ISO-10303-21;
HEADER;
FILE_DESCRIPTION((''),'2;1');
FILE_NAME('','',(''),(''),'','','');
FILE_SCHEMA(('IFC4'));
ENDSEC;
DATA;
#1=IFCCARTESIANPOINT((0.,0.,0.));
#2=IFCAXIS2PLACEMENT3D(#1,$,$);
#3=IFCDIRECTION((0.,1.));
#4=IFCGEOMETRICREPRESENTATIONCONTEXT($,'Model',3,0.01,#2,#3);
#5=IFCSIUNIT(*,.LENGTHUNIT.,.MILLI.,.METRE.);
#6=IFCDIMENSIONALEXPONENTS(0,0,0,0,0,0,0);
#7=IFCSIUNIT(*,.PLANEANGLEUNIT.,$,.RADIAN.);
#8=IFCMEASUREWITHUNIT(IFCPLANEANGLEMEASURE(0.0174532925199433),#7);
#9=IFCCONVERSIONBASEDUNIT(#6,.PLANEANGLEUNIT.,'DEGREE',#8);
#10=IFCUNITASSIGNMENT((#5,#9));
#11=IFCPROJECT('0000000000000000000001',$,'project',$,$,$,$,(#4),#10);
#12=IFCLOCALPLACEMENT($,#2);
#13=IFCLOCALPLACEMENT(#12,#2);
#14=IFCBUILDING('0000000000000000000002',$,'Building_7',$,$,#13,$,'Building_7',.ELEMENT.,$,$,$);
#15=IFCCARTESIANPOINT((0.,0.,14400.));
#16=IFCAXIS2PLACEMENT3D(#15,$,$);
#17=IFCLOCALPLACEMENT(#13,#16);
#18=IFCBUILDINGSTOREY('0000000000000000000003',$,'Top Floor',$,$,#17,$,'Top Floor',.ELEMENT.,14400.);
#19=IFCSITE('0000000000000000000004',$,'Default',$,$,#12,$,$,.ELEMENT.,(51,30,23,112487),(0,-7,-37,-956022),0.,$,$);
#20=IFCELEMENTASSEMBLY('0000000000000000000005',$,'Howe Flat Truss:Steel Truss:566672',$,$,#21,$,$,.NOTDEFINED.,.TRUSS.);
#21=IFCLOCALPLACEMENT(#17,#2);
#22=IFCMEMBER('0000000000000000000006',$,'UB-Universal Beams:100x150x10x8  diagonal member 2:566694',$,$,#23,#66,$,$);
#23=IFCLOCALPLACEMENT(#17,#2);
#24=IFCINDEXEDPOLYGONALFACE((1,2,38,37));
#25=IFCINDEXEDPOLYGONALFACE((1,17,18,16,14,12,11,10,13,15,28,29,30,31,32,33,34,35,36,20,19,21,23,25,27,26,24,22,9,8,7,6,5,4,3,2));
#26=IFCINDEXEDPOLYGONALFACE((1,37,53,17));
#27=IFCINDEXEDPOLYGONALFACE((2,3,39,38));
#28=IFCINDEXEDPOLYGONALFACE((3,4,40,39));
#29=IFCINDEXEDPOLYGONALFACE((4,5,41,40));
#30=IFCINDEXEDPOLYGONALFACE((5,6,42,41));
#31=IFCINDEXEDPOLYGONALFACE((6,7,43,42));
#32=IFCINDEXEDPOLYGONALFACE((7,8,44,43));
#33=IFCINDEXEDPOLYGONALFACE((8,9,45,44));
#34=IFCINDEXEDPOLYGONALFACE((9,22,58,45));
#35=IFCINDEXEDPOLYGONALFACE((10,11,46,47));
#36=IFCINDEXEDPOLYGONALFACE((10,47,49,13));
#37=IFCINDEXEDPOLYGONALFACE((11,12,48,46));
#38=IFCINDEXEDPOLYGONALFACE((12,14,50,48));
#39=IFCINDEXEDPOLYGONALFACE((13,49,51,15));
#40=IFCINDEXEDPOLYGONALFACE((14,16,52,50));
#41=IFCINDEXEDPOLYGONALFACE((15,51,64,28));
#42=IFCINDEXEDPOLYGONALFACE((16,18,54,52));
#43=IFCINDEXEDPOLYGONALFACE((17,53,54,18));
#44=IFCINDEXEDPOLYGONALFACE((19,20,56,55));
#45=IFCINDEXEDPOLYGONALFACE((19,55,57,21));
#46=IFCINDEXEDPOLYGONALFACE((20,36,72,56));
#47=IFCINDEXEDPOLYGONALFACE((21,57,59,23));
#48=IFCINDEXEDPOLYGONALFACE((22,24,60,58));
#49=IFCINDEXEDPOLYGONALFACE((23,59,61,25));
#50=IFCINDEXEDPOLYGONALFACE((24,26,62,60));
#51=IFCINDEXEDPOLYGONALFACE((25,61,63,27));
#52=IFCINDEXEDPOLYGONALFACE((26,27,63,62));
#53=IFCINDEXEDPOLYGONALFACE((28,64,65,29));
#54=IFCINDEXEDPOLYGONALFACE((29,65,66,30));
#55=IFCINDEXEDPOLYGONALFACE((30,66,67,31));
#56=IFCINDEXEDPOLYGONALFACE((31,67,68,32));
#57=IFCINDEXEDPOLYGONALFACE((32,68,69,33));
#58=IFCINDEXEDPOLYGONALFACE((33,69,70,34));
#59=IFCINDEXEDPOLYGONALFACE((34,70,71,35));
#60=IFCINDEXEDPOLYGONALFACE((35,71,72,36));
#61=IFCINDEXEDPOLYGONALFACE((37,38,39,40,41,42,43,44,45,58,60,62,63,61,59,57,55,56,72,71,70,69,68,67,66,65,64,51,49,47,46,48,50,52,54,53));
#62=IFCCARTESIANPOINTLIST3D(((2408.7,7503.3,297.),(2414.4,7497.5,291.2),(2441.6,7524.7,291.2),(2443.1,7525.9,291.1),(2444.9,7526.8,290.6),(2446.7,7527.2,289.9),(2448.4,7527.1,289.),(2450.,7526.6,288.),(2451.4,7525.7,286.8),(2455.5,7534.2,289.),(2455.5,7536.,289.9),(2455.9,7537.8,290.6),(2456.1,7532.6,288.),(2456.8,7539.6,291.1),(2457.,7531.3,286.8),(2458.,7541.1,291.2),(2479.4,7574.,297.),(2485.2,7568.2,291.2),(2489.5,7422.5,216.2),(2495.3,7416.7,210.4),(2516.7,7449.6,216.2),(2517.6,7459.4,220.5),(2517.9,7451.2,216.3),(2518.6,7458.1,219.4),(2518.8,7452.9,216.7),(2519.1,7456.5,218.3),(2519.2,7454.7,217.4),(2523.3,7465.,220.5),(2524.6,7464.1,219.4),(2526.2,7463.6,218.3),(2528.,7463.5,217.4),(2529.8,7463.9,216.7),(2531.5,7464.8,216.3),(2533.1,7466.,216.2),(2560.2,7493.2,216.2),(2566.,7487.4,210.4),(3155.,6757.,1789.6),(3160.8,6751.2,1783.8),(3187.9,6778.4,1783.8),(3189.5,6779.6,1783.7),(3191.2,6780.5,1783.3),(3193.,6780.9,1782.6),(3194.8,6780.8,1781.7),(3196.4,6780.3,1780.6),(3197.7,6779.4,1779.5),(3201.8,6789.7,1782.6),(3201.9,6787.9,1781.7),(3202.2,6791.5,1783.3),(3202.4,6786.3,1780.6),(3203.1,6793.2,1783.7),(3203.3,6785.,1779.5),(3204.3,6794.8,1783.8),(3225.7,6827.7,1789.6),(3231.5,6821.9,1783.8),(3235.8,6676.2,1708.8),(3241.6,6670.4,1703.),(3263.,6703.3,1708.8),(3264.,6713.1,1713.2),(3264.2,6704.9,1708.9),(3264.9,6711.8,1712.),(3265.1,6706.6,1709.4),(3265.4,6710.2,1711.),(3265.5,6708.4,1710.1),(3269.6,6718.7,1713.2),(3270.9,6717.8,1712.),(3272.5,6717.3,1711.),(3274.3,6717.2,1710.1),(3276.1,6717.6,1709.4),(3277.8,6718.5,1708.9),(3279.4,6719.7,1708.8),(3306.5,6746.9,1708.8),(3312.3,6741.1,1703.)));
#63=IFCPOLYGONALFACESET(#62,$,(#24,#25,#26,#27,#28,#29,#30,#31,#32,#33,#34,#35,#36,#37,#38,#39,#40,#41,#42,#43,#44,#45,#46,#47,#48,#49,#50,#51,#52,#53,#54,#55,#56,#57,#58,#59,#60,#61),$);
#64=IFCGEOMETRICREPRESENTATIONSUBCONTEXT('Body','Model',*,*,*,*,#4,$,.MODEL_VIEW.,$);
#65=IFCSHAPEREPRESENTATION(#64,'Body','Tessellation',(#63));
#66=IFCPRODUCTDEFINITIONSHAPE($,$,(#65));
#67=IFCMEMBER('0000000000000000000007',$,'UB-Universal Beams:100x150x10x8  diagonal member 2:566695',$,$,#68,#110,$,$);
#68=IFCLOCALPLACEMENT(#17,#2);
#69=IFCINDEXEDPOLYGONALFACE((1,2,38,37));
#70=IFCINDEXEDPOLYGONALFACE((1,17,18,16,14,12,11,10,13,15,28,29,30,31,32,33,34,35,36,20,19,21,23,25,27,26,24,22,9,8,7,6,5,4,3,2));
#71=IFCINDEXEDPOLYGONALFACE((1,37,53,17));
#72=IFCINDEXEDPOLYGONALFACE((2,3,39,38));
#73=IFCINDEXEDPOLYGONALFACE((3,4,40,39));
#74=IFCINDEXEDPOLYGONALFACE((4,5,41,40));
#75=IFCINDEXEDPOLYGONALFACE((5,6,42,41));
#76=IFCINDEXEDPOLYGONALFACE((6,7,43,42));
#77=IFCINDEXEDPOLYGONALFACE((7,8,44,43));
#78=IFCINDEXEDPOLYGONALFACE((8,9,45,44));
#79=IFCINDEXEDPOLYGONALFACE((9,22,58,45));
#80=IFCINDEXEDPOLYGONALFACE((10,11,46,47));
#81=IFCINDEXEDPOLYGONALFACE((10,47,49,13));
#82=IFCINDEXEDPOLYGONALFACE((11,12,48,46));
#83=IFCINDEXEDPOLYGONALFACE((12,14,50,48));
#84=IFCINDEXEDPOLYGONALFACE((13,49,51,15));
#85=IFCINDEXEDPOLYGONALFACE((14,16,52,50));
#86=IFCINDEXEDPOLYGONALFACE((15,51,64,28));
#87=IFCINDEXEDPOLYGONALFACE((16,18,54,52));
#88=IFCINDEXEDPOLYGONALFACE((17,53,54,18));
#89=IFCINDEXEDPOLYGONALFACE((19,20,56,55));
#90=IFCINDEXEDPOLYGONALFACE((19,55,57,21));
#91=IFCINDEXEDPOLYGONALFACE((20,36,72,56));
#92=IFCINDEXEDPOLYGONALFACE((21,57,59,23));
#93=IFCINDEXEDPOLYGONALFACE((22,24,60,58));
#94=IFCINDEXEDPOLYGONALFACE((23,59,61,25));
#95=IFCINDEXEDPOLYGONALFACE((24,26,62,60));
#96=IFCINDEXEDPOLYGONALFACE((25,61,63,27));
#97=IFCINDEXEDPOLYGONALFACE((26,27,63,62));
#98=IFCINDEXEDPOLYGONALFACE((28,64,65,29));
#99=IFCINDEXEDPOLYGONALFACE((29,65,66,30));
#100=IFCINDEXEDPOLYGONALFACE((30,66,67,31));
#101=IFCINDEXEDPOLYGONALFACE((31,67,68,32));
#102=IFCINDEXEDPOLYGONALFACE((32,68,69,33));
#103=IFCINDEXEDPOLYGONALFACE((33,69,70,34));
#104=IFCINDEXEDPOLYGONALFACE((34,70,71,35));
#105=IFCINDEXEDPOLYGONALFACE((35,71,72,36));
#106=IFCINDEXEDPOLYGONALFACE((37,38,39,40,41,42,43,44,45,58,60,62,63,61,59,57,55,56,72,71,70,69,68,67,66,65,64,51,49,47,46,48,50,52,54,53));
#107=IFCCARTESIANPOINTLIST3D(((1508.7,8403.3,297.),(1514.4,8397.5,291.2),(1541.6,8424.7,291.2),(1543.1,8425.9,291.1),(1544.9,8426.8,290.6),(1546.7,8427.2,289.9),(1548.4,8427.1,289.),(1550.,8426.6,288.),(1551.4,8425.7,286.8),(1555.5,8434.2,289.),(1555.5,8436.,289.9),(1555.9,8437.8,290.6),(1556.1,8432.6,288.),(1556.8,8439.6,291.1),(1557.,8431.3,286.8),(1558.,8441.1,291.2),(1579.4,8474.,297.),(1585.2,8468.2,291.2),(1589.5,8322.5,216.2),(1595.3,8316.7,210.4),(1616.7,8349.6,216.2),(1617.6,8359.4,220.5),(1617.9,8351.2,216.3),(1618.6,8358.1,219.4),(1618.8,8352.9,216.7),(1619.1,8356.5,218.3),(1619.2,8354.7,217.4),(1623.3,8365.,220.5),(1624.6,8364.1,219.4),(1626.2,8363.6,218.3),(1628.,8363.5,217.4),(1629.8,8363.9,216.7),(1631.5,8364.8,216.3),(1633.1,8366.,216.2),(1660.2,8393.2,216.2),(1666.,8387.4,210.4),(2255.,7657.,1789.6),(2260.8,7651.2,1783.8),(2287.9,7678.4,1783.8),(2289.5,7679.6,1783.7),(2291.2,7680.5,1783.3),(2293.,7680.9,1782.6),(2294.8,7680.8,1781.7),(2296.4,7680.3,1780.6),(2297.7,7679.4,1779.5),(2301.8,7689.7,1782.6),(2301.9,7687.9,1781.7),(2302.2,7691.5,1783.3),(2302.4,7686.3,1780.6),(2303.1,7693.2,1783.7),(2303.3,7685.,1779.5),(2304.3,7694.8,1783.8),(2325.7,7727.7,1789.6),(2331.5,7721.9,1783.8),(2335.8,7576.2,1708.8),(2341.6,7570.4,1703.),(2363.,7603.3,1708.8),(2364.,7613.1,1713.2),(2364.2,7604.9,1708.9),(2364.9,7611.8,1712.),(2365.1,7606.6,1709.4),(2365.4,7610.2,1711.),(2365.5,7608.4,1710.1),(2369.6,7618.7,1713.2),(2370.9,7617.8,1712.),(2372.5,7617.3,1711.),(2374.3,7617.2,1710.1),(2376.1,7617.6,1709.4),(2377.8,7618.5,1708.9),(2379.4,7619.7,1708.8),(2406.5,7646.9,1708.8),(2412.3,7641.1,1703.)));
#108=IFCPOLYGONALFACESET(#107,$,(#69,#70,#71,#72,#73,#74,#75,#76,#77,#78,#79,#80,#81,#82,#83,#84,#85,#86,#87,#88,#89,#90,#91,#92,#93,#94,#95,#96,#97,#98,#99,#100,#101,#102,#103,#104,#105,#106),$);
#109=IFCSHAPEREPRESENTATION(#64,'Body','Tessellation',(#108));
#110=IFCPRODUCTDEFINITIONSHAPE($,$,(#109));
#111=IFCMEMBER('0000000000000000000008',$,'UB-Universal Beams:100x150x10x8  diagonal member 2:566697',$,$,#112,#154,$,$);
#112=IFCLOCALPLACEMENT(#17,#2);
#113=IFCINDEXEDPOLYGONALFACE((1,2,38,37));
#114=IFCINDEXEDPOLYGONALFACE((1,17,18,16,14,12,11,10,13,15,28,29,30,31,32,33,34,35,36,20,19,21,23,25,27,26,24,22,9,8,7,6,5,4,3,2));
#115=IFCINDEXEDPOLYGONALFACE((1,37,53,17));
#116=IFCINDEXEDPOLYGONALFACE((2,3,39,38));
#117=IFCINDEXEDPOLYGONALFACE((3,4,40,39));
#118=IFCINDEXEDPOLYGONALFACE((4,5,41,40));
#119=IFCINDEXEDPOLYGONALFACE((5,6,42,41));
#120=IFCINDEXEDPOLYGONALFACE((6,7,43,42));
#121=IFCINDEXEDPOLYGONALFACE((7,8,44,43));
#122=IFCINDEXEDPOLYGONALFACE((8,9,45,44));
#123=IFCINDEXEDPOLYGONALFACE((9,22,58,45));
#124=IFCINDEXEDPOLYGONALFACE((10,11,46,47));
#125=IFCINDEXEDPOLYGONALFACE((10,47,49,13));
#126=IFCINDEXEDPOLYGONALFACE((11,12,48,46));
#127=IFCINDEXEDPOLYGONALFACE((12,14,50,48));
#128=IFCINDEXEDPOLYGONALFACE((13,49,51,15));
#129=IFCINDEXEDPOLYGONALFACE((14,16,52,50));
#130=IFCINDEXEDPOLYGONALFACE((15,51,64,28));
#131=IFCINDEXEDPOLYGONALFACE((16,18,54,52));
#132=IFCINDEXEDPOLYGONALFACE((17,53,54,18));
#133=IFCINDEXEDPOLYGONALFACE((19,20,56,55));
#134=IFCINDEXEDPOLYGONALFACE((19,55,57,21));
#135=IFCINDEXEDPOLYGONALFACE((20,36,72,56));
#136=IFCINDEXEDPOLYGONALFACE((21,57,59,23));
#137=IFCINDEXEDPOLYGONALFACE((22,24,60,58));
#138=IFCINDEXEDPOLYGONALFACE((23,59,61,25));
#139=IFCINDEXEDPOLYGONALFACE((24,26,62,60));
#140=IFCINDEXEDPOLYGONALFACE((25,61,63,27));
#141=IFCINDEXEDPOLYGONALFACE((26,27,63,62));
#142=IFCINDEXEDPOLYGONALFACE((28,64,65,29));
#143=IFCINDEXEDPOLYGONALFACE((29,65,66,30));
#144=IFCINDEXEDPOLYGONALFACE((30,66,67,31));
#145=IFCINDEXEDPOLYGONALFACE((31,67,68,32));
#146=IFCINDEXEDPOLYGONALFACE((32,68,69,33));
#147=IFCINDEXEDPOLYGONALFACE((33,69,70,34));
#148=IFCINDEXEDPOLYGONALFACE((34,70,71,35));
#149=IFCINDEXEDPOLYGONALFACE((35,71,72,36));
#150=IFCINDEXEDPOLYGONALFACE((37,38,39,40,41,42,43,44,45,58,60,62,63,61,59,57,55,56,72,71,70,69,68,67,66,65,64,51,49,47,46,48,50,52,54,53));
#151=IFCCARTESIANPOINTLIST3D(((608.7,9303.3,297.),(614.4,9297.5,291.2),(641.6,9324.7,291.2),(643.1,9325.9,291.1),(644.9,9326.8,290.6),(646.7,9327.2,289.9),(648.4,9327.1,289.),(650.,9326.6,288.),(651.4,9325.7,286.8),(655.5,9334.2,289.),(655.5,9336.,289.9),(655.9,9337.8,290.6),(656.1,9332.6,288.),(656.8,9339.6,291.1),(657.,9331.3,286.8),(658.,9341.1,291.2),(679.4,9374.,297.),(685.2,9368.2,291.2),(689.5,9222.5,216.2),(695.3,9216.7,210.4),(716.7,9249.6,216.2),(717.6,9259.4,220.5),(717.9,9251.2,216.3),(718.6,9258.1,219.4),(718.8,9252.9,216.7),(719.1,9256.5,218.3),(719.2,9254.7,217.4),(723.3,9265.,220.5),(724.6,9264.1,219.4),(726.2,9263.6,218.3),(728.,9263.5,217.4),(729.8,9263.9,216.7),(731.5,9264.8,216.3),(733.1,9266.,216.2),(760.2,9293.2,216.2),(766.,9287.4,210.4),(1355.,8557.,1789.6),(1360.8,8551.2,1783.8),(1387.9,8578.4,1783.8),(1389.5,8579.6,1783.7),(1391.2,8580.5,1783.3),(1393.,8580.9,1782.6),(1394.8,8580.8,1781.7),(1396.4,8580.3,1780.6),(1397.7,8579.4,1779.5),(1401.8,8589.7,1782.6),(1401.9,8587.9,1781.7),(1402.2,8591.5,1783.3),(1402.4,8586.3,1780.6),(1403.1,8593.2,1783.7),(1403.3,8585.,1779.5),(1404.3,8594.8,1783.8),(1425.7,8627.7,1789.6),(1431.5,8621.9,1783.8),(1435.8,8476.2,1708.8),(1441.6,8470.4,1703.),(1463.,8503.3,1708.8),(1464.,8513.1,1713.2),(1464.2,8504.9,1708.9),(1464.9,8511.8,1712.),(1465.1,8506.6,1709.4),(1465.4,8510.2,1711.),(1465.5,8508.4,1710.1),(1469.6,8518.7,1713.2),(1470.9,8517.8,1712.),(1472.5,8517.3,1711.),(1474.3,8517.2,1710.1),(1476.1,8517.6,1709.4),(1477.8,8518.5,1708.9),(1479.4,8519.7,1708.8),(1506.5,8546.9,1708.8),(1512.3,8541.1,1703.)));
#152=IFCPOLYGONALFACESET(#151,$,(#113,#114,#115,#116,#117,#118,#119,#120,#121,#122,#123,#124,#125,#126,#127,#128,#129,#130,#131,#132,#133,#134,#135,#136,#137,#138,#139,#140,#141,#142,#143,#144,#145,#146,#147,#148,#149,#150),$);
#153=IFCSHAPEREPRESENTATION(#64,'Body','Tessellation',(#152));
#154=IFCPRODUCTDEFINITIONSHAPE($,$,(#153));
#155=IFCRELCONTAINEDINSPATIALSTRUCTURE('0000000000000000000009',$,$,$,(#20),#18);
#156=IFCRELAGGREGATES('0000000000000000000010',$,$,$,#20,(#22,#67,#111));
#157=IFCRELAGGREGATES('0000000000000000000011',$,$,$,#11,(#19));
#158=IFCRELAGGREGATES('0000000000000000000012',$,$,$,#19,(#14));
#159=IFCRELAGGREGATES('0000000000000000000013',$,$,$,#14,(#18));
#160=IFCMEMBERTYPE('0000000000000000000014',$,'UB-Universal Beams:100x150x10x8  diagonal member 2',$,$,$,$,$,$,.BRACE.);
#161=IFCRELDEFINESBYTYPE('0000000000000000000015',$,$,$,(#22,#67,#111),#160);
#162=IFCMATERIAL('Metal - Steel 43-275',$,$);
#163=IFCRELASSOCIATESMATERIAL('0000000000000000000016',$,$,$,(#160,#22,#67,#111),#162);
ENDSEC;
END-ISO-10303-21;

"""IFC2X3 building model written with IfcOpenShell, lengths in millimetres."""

from ifc_helpers import new_model, entity, si_unit, converted_unit, direction, frame, frame_2d, origin, place, context, subcontext, project, spatial, polyline, circle_curve, parameter, trimmed, segment, composite_curve, outline, extrude, source, transform, mapped, material, type_object, type_shapes, element, aggregate, save


model = new_model("IFC2X3")

# Units and contexts
model_context = context("Model", 3, precision=0.01, world=origin(), true_north=direction((0.0, 1.0)))
body_context = subcontext(model_context, "Body", "Model", "MODEL_VIEW")
ifc_project = project(units=[si_unit("LENGTHUNIT", "METRE", prefix="MILLI"), converted_unit("PLANEANGLEUNIT", "DEGREE", entity("IfcPlaneAngleMeasure", 0.0174532925199433), si_unit("PLANEANGLEUNIT", "RADIAN"), dimensions=[0, 0, 0, 0, 0, 0, 0])], contexts=[model_context])

# Site, building, storey
site_placement = place(None, origin())
site = spatial("IfcSite", under=ifc_project, at=site_placement, Name="Default", CompositionType="ELEMENT", RefLatitude=(51, 30, 23, 112487), RefLongitude=(0, -7, -37, -956022), RefElevation=0.0)
building_placement = place(site_placement, origin())
building = spatial("IfcBuilding", under=site, at=building_placement, Name="Building_7", LongName="Building_7", CompositionType="ELEMENT")
storey_placement = place(building_placement, frame((0.0, 0.0, 14400.0)))
storey = spatial("IfcBuildingStorey", under=building, at=storey_placement, Name="Top Floor", LongName="Top Floor", CompositionType="ELEMENT", Elevation=14400.0)

# Shared definitions
ifc_material = material(Name="Metal - Steel 43-275")

# Element assembly
assembly_1_placement = place(storey_placement, origin())
assembly_1 = element("IfcElementAssembly", 1, at=assembly_1_placement, inside=storey, Name="Howe Flat Truss:Steel Truss:566672", AssemblyPlace="NOTDEFINED", PredefinedType="TRUSS")

# Members
member_type_1 = type_object("IfcMemberType", Name="UB-Universal Beams:100x150x10x8  diagonal member 2", PredefinedType="BRACE", material=ifc_material)
shared_shape_1 = source(origin(), body_context, "Body", "SweptSolid", [
    extrude(outline(composite_curve([segment(polyline([(-50.0, -65.0), (-50.0, -75.0)]), True, "CONTINUOUS"), segment(polyline([(-50.0, -75.0), (50.0, -75.0)]), True, "CONTINUOUS"), segment(polyline([(50.0, -75.0), (50.0, -65.0)]), True, "CONTINUOUS"), segment(polyline([(50.0, -65.0), (11.6, -65.0)]), True, "CONTINUOUS"), segment(trimmed(circle_curve(frame_2d((11.6, -57.4), x_axis=(1.0, 0.0)), 7.6), [parameter(180.0)], [parameter(270.0)], True, "PARAMETER"), False, "CONTINUOUS"), segment(polyline([(4.0, -57.4), (4.0, 57.4)]), True, "CONTINUOUS"), segment(trimmed(circle_curve(frame_2d((11.6, 57.4), x_axis=(1.0, 0.0)), 7.6), [parameter(90.0)], [parameter(180.0)], True, "PARAMETER"), False, "CONTINUOUS"), segment(polyline([(11.6, 65.0), (50.0, 65.0)]), True, "CONTINUOUS"), segment(polyline([(50.0, 65.0), (50.0, 75.0)]), True, "CONTINUOUS"), segment(polyline([(50.0, 75.0), (-50.0, 75.0)]), True, "CONTINUOUS"), segment(polyline([(-50.0, 75.0), (-50.0, 65.0)]), True, "CONTINUOUS"), segment(polyline([(-50.0, 65.0), (-11.6, 65.0)]), True, "CONTINUOUS"), segment(trimmed(circle_curve(frame_2d((-11.6, 57.4), x_axis=(1.0, 0.0)), 7.6), [parameter(360.0)], [parameter(90.0)], True, "PARAMETER"), False, "CONTINUOUS"), segment(polyline([(-4.0, 57.4), (-4.0, -57.4)]), True, "CONTINUOUS"), segment(trimmed(circle_curve(frame_2d((-11.6, -57.4), x_axis=(1.0, 0.0)), 7.6), [parameter(270.0)], [parameter(360.0)], True, "PARAMETER"), False, "CONTINUOUS"), segment(polyline([(-11.6, -65.0), (-50.0, -65.0)]), True, "CONTINUOUS")], self_intersect=False)), frame((-914.0, 0.0, 0.0), z_axis=(-1.0, 0.0, 0.0), x_axis=(0.0, -1.0, 0.0)), (0.0, 0.0, -1.0), 1828.1),
])
type_shapes(member_type_1, [shared_shape_1])
member_1_placement = place(assembly_1_placement, frame((2860.5, 7122.2, 1000.0), z_axis=(0.57735, -0.57735, -0.57735), x_axis=(-0.408248, 0.408248, -0.816497)))
member_1 = element("IfcMember", 2, at=member_1_placement, type_object=member_type_1, material=ifc_material, Name="UB-Universal Beams:100x150x10x8  diagonal member 2:566694", context=body_context, shape_type="MappedRepresentation", body=[
    mapped(shared_shape_1, transform((0.0, 0.0, 0.0), scale=1.0)),
])
member_2_placement = place(assembly_1_placement, frame((1960.5, 8022.2, 1000.0), z_axis=(0.57735, -0.57735, -0.57735), x_axis=(-0.408248, 0.408248, -0.816497)))
member_2 = element("IfcMember", 3, at=member_2_placement, type_object=member_type_1, material=ifc_material, Name="UB-Universal Beams:100x150x10x8  diagonal member 2:566695", context=body_context, shape_type="MappedRepresentation", body=[
    mapped(shared_shape_1, transform((0.0, 0.0, 0.0), scale=1.0)),
])
member_3_placement = place(assembly_1_placement, frame((1060.5, 8922.2, 1000.0), z_axis=(0.57735, -0.57735, -0.57735), x_axis=(-0.408248, 0.408248, -0.816497)))
member_3 = element("IfcMember", 4, at=member_3_placement, type_object=member_type_1, material=ifc_material, Name="UB-Universal Beams:100x150x10x8  diagonal member 2:566697", context=body_context, shape_type="MappedRepresentation", body=[
    mapped(shared_shape_1, transform((0.0, 0.0, 0.0), scale=1.0)),
])
aggregate(assembly_1, [member_1, member_2, member_3])

save(model, "model.ifc")
